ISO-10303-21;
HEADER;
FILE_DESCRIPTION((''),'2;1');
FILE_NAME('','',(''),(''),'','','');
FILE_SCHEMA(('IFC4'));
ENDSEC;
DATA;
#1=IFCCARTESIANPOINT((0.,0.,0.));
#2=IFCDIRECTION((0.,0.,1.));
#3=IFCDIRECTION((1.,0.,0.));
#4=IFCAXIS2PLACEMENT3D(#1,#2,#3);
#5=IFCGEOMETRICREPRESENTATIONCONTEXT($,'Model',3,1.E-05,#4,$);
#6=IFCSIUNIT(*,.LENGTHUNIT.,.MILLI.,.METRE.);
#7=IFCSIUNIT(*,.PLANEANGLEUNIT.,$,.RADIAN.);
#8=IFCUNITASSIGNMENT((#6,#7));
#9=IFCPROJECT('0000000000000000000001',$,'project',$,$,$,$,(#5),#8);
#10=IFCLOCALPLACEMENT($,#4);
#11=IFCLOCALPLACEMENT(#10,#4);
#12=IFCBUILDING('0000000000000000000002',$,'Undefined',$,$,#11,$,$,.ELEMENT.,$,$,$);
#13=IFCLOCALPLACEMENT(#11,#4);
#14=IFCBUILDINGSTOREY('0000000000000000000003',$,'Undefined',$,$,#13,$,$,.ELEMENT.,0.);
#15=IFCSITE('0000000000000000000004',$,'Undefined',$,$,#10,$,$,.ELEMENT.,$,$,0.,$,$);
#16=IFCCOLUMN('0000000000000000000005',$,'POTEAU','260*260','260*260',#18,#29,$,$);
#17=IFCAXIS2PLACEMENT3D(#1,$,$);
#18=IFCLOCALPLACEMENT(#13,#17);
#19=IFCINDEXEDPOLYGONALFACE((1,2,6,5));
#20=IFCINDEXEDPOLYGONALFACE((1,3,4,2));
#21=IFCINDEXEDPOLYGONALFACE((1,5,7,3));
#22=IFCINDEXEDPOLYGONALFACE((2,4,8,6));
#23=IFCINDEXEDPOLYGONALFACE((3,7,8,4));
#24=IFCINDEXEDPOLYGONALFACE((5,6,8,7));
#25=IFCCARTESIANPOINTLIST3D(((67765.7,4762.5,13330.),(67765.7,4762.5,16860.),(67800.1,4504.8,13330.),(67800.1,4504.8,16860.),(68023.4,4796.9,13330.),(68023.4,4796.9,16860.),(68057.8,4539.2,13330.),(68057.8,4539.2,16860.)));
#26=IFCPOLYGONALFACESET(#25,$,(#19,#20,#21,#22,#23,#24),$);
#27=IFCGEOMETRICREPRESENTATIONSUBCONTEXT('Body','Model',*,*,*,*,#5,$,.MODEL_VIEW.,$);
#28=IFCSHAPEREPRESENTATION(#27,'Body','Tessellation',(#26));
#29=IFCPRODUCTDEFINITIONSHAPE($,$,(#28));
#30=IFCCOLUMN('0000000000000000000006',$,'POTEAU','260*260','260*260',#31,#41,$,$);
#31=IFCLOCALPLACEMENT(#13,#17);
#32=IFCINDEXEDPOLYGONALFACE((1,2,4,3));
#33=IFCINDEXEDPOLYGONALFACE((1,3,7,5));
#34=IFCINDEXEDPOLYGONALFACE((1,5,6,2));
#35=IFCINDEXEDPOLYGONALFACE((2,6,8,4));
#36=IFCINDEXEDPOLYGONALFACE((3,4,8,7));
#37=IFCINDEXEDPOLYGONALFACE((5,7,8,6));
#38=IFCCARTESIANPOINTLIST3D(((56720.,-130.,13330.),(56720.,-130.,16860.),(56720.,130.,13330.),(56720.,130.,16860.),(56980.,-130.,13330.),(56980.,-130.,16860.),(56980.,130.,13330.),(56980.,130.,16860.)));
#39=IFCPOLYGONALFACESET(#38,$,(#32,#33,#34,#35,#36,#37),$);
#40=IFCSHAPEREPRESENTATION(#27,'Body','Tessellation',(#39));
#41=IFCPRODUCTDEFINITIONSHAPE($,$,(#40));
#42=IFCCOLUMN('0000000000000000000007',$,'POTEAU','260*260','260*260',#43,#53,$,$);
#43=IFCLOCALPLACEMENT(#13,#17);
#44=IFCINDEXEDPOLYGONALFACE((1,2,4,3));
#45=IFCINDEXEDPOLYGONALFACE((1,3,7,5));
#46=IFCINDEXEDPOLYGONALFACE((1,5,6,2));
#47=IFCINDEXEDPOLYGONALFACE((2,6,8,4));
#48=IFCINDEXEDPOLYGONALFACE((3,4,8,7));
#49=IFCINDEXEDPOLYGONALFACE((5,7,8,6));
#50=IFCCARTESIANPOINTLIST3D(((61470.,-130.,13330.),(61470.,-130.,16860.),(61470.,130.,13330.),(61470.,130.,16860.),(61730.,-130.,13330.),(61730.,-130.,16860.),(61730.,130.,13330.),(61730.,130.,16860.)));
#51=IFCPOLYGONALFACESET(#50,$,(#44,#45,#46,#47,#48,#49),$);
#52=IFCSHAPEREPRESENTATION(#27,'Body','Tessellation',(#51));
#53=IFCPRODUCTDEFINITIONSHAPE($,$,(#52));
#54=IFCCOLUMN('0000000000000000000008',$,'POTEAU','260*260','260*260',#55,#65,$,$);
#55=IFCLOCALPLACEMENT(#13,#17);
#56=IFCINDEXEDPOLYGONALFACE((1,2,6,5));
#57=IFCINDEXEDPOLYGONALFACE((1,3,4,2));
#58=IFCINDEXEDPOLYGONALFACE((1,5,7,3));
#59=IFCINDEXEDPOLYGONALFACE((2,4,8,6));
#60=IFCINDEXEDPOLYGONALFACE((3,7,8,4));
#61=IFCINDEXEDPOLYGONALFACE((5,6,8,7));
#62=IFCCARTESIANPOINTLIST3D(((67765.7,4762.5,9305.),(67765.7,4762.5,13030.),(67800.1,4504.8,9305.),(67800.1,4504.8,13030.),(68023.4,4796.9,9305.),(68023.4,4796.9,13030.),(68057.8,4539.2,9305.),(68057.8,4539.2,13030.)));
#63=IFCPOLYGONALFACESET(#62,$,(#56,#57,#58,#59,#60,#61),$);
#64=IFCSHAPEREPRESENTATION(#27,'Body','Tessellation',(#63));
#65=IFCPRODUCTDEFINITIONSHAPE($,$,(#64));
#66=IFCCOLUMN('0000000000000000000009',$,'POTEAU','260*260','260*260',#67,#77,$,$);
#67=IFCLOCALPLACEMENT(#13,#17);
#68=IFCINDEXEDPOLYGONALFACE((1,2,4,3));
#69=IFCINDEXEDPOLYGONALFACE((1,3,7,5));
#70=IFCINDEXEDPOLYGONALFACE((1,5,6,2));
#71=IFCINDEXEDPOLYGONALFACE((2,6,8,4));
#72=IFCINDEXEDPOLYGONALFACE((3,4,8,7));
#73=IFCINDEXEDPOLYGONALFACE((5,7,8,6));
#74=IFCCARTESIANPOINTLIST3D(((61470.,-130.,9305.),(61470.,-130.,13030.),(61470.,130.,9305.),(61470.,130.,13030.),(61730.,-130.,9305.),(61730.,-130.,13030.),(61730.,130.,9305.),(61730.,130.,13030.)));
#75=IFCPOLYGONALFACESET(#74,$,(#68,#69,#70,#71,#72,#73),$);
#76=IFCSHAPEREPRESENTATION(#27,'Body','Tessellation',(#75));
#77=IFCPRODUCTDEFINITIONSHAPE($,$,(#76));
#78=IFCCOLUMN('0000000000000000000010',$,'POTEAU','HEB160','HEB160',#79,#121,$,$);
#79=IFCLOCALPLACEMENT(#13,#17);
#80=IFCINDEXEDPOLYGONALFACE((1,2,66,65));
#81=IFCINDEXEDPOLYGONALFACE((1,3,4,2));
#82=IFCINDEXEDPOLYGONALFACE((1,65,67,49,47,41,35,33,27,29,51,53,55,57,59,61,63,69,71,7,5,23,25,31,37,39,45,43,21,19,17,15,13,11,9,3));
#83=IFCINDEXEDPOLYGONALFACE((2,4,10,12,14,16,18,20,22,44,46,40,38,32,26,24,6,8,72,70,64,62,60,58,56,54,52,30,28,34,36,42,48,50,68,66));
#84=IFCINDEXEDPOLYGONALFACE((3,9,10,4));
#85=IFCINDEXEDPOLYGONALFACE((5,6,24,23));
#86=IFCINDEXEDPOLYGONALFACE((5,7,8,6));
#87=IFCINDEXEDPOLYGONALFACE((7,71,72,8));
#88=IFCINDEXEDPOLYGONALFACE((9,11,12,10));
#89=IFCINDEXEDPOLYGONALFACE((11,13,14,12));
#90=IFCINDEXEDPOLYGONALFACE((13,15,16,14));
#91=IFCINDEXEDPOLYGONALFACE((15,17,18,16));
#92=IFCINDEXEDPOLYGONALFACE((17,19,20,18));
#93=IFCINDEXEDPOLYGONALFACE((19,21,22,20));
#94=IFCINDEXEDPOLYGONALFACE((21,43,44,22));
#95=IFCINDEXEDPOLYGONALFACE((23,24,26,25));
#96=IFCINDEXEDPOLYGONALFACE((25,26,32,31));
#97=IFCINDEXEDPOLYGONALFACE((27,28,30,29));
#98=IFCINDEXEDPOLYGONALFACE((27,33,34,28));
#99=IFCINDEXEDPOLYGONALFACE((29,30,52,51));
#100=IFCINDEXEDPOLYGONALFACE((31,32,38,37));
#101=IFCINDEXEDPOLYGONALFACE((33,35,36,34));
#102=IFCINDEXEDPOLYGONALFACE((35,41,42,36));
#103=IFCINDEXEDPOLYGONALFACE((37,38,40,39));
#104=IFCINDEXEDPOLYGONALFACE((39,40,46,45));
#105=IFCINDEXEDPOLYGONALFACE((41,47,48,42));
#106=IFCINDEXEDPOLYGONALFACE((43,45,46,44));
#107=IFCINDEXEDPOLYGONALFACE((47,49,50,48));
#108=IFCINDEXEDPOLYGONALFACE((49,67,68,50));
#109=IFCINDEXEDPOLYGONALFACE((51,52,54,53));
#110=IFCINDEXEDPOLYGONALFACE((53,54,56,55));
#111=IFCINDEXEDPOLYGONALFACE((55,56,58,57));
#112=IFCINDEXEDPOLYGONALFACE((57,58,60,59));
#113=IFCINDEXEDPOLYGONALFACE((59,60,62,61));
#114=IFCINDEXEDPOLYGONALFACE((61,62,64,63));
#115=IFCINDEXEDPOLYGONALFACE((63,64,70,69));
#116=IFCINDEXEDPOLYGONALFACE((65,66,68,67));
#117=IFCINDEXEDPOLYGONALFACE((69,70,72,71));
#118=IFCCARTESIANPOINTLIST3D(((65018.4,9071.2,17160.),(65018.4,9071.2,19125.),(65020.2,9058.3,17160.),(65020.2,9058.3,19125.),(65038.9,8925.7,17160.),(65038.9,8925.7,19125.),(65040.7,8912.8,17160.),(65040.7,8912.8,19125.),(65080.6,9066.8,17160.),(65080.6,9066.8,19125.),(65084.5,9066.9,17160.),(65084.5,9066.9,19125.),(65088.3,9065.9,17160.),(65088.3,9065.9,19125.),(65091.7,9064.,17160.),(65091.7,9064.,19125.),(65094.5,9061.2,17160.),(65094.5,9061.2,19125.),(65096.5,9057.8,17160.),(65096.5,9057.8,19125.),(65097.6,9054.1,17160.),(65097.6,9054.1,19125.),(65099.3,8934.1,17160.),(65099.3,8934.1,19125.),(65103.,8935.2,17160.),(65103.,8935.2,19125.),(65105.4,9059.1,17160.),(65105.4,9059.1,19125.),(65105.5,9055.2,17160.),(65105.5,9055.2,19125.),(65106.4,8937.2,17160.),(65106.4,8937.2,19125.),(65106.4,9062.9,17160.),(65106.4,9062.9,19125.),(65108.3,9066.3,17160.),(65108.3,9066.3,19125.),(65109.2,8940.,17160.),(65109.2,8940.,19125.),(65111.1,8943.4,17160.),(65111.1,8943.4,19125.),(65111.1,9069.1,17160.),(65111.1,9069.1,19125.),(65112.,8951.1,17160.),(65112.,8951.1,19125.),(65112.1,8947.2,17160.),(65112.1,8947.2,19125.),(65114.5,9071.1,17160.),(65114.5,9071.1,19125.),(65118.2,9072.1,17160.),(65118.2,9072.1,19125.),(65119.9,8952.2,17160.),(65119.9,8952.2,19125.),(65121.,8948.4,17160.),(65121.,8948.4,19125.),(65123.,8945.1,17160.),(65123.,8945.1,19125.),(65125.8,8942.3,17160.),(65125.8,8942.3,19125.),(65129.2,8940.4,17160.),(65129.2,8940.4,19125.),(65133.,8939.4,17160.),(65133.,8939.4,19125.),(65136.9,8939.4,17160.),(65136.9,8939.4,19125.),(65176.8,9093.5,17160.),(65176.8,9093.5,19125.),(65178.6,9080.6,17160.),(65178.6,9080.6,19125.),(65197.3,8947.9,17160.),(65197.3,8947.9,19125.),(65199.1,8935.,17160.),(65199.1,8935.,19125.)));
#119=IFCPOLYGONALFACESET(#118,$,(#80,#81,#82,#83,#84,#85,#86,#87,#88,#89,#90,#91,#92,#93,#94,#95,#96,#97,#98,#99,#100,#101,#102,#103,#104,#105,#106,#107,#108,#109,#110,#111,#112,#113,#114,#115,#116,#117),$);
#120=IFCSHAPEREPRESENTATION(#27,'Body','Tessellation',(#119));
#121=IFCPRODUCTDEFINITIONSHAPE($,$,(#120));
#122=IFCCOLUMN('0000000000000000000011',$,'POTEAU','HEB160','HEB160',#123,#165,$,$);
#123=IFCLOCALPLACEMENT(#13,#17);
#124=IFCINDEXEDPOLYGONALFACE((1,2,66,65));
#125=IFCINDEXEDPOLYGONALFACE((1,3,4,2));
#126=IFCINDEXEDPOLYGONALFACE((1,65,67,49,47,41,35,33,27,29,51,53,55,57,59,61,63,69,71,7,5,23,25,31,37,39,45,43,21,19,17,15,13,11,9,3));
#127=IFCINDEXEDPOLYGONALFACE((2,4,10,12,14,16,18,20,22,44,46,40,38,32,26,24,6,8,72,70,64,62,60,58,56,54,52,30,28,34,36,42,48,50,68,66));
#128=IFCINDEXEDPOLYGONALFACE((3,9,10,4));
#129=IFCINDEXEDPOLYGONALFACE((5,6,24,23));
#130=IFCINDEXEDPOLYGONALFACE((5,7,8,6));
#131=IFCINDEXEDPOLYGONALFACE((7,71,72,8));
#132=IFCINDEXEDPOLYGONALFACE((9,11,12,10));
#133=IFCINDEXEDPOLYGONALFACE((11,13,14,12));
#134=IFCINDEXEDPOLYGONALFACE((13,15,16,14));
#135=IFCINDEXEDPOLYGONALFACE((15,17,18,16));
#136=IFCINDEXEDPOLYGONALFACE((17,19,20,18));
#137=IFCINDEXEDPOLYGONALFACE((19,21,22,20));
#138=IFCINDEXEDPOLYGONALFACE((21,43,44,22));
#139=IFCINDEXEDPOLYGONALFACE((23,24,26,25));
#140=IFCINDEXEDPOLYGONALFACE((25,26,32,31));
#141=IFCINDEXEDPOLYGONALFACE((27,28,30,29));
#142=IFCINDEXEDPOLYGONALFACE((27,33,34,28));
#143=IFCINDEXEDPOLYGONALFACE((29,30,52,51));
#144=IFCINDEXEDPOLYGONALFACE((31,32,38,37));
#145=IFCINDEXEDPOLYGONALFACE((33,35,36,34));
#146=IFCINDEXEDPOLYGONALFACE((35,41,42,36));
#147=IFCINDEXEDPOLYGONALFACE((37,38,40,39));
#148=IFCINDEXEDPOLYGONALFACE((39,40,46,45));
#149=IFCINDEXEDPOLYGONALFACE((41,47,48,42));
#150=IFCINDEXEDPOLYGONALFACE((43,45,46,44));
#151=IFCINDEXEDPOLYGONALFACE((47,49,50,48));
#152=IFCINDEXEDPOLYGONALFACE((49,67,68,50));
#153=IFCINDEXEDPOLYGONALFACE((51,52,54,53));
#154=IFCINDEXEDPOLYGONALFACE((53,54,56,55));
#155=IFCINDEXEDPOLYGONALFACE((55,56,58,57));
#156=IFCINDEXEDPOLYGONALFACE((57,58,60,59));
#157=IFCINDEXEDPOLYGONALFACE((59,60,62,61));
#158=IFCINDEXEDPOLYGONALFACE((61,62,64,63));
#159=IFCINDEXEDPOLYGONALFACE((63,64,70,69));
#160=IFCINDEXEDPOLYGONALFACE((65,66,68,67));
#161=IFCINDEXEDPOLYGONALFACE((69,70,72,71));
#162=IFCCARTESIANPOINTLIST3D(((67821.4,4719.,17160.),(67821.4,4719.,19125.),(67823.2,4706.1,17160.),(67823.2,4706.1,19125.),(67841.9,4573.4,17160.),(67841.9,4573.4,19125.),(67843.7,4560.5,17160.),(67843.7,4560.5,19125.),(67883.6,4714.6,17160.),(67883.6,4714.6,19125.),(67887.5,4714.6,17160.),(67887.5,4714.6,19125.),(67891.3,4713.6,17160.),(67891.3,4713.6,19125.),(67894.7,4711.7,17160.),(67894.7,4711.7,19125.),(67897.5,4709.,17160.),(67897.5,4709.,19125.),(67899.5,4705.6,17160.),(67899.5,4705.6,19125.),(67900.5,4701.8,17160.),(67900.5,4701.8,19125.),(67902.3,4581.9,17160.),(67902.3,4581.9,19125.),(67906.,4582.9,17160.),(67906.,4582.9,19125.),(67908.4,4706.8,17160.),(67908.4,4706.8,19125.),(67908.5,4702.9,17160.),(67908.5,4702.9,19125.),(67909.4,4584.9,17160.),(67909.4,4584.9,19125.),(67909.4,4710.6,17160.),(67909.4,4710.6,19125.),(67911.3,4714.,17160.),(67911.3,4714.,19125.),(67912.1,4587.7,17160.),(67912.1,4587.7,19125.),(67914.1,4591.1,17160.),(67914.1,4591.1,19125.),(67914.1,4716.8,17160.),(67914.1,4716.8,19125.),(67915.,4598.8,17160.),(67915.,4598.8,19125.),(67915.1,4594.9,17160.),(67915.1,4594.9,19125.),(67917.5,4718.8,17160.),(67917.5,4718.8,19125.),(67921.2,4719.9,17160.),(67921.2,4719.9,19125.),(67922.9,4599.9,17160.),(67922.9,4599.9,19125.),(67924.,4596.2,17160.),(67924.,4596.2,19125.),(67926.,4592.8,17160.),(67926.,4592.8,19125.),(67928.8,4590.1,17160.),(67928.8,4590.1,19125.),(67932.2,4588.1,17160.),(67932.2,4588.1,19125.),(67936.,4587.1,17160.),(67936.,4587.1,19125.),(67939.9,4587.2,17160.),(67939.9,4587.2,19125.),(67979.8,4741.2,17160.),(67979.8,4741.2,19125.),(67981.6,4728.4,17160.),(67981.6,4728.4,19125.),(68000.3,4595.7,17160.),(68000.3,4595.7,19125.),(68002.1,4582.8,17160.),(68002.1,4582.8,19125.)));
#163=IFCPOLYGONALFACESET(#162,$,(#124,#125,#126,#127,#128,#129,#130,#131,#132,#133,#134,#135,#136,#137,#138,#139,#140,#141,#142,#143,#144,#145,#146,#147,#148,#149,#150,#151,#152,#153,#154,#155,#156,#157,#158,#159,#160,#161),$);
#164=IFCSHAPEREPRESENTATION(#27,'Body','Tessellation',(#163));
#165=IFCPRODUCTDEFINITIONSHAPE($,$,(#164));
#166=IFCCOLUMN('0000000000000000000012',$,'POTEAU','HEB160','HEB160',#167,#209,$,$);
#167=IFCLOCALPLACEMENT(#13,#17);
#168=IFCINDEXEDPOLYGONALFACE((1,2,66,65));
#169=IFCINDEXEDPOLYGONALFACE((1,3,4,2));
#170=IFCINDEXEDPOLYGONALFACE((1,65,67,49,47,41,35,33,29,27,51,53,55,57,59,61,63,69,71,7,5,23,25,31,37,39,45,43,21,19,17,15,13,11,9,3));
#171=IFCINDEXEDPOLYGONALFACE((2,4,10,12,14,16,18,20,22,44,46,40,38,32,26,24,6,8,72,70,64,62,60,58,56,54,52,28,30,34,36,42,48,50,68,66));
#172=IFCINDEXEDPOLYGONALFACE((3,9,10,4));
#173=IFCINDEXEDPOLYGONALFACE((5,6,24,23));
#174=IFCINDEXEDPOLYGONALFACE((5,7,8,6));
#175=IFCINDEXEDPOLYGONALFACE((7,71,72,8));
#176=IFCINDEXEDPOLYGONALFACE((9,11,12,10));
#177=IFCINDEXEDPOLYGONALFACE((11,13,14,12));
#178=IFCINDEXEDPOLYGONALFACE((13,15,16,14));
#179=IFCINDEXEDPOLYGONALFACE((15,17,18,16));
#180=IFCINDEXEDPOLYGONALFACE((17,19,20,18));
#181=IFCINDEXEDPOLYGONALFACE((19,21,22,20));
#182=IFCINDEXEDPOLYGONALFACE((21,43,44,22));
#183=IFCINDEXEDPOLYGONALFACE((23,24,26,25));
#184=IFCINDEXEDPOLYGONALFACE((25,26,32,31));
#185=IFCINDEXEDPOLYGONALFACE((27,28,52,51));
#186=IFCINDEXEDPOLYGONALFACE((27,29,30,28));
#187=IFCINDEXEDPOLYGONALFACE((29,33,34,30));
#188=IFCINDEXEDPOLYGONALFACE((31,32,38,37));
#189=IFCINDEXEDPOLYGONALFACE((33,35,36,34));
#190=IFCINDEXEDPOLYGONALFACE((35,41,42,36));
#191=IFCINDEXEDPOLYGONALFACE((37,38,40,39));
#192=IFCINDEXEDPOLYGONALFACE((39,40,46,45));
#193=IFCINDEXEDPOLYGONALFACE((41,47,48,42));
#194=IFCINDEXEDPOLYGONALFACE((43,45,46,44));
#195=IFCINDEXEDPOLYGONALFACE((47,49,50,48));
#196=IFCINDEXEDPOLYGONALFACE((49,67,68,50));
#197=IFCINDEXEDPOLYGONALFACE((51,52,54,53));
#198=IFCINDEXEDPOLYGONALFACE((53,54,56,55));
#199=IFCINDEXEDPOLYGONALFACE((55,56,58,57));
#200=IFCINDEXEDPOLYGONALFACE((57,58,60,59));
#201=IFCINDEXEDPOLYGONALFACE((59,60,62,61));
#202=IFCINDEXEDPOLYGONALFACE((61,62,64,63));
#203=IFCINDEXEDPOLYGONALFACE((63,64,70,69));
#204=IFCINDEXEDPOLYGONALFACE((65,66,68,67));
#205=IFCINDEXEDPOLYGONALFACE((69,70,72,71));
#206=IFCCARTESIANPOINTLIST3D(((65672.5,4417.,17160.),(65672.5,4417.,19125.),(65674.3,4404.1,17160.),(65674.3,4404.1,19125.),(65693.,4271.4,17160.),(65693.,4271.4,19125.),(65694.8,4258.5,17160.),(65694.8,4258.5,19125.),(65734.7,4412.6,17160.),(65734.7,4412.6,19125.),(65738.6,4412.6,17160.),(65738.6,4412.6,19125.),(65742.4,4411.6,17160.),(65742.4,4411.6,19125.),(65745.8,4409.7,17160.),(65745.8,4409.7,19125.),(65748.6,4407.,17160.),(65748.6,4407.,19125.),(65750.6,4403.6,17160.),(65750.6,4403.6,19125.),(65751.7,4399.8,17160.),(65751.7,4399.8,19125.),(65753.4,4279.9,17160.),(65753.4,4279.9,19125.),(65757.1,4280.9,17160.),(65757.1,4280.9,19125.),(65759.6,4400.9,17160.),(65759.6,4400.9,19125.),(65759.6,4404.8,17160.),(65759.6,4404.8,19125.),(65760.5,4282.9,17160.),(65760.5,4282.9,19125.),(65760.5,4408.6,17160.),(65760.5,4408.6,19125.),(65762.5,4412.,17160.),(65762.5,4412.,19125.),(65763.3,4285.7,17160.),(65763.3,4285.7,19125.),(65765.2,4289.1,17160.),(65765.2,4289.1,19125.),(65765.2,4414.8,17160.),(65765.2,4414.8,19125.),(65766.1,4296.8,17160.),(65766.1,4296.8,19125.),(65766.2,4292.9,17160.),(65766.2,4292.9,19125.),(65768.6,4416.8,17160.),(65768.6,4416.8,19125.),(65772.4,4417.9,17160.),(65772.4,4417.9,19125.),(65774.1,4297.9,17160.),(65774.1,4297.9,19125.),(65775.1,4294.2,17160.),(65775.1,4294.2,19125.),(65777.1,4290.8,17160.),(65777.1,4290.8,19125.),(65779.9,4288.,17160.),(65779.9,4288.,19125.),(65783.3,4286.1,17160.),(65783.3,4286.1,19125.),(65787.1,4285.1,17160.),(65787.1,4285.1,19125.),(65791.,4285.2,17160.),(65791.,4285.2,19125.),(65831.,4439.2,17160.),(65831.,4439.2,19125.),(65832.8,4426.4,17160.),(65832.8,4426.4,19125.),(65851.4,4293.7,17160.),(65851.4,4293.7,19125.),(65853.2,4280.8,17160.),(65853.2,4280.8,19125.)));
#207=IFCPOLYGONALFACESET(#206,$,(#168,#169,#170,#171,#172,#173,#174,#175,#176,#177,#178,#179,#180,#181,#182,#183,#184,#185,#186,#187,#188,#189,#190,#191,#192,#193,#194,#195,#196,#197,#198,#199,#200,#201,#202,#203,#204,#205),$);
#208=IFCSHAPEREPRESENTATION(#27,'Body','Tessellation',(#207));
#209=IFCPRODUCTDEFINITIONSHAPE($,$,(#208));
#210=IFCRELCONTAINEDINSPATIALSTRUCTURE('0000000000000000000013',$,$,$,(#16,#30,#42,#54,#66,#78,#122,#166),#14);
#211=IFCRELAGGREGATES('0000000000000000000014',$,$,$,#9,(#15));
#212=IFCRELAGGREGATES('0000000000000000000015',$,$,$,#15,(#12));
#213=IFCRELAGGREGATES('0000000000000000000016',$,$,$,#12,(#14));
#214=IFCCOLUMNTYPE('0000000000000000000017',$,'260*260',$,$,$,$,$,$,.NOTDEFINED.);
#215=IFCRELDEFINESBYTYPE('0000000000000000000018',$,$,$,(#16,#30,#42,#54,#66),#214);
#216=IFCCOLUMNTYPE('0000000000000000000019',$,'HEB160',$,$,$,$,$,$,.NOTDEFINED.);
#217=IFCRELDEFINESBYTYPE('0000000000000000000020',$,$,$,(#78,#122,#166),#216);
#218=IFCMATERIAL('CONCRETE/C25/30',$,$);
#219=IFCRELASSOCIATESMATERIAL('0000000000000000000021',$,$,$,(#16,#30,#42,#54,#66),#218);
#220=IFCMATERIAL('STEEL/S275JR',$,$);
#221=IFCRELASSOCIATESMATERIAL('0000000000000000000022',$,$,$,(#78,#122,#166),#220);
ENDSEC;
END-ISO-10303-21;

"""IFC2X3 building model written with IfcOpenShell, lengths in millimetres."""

from ifc_helpers import new_model, si_unit, frame, origin_with_axes, origin_2d_with_axis, place, context, subcontext, project, spatial, rectangle, i_section, extrude, material, type_object, element, save


model = new_model("IFC2X3")

# Units and contexts
model_context = context("Model", 3, precision=1e-05, world=origin_with_axes())
body_context = subcontext(model_context, "Body", "Model", "MODEL_VIEW")
ifc_project = project(units=[si_unit("LENGTHUNIT", "METRE", prefix="MILLI"), si_unit("PLANEANGLEUNIT", "RADIAN")], contexts=[model_context])

# Site, building, storey
site_placement = place(None, origin_with_axes())
site = spatial("IfcSite", under=ifc_project, at=site_placement, Name="Undefined", CompositionType="ELEMENT", RefElevation=0.0)
building_placement = place(site_placement, origin_with_axes())
building = spatial("IfcBuilding", under=site, at=building_placement, Name="Undefined", CompositionType="ELEMENT")
storey_placement = place(building_placement, origin_with_axes())
storey = spatial("IfcBuildingStorey", under=building, at=storey_placement, Name="Undefined", CompositionType="ELEMENT", Elevation=0.0)

# Columns
ifc_material_1 = material(Name="CONCRETE/C25/30")
column_type_1 = type_object("IfcColumnType", Name="260*260", PredefinedType="NOTDEFINED")
column_1_placement = place(storey_placement, frame((67911.7, 4650.9, 13330.0), z_axis=(0.0, 0.0, 1.0), x_axis=(1.0, 0.0, 0.0)))
element("IfcColumn", 1, at=column_1_placement, inside=storey, type_object=column_type_1, material=ifc_material_1, Name="POTEAU", Description="260*260", ObjectType="260*260", context=body_context, shape_type="SweptSolid", body=[
    extrude(rectangle(XDim=260.0, YDim=260.0, at=origin_2d_with_axis()), frame((0.0, 0.0, 3530.0), z_axis=(0.0, 0.0, -1.0), x_axis=(0.132256, -0.991216, 0.0)), (0.0, 0.0, 1.0), 3530.0),
])
for number, where, z_axis, x_axis, name in (
    (2, (56850.0, 0.0, 13330.0), (0.0, 0.0, 1.0), (1.0, 0.0, 0.0), "POTEAU"),
    (3, (61600.0, 0.0, 13330.0), (0.0, 0.0, 1.0), (1.0, 0.0, 0.0), "POTEAU"),
):
    element("IfcColumn", number, at=place(storey_placement, frame(where, z_axis=z_axis, x_axis=x_axis)), inside=storey, type_object=column_type_1, material=ifc_material_1, Name=name, Description="260*260", ObjectType="260*260", context=body_context, shape_type="SweptSolid", body=[
        extrude(rectangle(XDim=260.0, YDim=260.0, at=origin_2d_with_axis()), frame((0.0, 0.0, 3530.0), z_axis=(0.0, 0.0, -1.0), x_axis=(-1.0, 0.0, 0.0)), (0.0, 0.0, 1.0), 3530.0),
    ])
column_2_placement = place(storey_placement, frame((67911.7, 4650.9, 9305.0), z_axis=(0.0, 0.0, 1.0), x_axis=(1.0, 0.0, 0.0)))
element("IfcColumn", 4, at=column_2_placement, inside=storey, type_object=column_type_1, material=ifc_material_1, Name="POTEAU", Description="260*260", ObjectType="260*260", context=body_context, shape_type="SweptSolid", body=[
    extrude(rectangle(XDim=260.0, YDim=260.0, at=origin_2d_with_axis()), frame((0.0, 0.0, 3725.0), z_axis=(0.0, 0.0, -1.0), x_axis=(0.132256, -0.991216, 0.0)), (0.0, 0.0, 1.0), 3725.0),
])
column_3_placement = place(storey_placement, frame((61600.0, 0.0, 9305.0), z_axis=(0.0, 0.0, 1.0), x_axis=(1.0, 0.0, 0.0)))
element("IfcColumn", 5, at=column_3_placement, inside=storey, type_object=column_type_1, material=ifc_material_1, Name="POTEAU", Description="260*260", ObjectType="260*260", context=body_context, shape_type="SweptSolid", body=[
    extrude(rectangle(XDim=260.0, YDim=260.0, at=origin_2d_with_axis()), frame((0.0, 0.0, 3725.0), z_axis=(0.0, 0.0, -1.0), x_axis=(-1.0, 0.0, 0.0)), (0.0, 0.0, 1.0), 3725.0),
])
ifc_material_2 = material(Name="STEEL/S275JR")
column_type_2 = type_object("IfcColumnType", Name="HEB160", PredefinedType="NOTDEFINED")
for number, where, z_axis, x_axis, name in (
    (6, (65108.8, 9003.1, 17160.0), (0.0, 0.0, 1.0), (1.0, 0.0, 0.0), "POTEAU"),
    (7, (67911.7, 4650.9, 17160.0), (0.0, 0.0, 1.0), (1.0, 0.0, 0.0), "POTEAU"),
    (8, (65762.9, 4348.9, 17160.0), (0.0, 0.0, 1.0), (1.0, 0.0, 0.0), "POTEAU"),
):
    element("IfcColumn", number, at=place(storey_placement, frame(where, z_axis=z_axis, x_axis=x_axis)), inside=storey, type_object=column_type_2, material=ifc_material_2, Name=name, Description="HEB160", ObjectType="HEB160", context=body_context, shape_type="SweptSolid", body=[
        extrude(i_section(OverallWidth=160.0, OverallDepth=160.0, WebThickness=8.0, FlangeThickness=13.0, FilletRadius=15.0, at=origin_2d_with_axis()), frame((0.0, 0.0, 1965.0), z_axis=(0.0, 0.0, -1.0), x_axis=(-0.990268, -0.139173, 0.0)), (0.0, 0.0, 1.0), 1965.0),
    ])

save(model, "model.ifc")
